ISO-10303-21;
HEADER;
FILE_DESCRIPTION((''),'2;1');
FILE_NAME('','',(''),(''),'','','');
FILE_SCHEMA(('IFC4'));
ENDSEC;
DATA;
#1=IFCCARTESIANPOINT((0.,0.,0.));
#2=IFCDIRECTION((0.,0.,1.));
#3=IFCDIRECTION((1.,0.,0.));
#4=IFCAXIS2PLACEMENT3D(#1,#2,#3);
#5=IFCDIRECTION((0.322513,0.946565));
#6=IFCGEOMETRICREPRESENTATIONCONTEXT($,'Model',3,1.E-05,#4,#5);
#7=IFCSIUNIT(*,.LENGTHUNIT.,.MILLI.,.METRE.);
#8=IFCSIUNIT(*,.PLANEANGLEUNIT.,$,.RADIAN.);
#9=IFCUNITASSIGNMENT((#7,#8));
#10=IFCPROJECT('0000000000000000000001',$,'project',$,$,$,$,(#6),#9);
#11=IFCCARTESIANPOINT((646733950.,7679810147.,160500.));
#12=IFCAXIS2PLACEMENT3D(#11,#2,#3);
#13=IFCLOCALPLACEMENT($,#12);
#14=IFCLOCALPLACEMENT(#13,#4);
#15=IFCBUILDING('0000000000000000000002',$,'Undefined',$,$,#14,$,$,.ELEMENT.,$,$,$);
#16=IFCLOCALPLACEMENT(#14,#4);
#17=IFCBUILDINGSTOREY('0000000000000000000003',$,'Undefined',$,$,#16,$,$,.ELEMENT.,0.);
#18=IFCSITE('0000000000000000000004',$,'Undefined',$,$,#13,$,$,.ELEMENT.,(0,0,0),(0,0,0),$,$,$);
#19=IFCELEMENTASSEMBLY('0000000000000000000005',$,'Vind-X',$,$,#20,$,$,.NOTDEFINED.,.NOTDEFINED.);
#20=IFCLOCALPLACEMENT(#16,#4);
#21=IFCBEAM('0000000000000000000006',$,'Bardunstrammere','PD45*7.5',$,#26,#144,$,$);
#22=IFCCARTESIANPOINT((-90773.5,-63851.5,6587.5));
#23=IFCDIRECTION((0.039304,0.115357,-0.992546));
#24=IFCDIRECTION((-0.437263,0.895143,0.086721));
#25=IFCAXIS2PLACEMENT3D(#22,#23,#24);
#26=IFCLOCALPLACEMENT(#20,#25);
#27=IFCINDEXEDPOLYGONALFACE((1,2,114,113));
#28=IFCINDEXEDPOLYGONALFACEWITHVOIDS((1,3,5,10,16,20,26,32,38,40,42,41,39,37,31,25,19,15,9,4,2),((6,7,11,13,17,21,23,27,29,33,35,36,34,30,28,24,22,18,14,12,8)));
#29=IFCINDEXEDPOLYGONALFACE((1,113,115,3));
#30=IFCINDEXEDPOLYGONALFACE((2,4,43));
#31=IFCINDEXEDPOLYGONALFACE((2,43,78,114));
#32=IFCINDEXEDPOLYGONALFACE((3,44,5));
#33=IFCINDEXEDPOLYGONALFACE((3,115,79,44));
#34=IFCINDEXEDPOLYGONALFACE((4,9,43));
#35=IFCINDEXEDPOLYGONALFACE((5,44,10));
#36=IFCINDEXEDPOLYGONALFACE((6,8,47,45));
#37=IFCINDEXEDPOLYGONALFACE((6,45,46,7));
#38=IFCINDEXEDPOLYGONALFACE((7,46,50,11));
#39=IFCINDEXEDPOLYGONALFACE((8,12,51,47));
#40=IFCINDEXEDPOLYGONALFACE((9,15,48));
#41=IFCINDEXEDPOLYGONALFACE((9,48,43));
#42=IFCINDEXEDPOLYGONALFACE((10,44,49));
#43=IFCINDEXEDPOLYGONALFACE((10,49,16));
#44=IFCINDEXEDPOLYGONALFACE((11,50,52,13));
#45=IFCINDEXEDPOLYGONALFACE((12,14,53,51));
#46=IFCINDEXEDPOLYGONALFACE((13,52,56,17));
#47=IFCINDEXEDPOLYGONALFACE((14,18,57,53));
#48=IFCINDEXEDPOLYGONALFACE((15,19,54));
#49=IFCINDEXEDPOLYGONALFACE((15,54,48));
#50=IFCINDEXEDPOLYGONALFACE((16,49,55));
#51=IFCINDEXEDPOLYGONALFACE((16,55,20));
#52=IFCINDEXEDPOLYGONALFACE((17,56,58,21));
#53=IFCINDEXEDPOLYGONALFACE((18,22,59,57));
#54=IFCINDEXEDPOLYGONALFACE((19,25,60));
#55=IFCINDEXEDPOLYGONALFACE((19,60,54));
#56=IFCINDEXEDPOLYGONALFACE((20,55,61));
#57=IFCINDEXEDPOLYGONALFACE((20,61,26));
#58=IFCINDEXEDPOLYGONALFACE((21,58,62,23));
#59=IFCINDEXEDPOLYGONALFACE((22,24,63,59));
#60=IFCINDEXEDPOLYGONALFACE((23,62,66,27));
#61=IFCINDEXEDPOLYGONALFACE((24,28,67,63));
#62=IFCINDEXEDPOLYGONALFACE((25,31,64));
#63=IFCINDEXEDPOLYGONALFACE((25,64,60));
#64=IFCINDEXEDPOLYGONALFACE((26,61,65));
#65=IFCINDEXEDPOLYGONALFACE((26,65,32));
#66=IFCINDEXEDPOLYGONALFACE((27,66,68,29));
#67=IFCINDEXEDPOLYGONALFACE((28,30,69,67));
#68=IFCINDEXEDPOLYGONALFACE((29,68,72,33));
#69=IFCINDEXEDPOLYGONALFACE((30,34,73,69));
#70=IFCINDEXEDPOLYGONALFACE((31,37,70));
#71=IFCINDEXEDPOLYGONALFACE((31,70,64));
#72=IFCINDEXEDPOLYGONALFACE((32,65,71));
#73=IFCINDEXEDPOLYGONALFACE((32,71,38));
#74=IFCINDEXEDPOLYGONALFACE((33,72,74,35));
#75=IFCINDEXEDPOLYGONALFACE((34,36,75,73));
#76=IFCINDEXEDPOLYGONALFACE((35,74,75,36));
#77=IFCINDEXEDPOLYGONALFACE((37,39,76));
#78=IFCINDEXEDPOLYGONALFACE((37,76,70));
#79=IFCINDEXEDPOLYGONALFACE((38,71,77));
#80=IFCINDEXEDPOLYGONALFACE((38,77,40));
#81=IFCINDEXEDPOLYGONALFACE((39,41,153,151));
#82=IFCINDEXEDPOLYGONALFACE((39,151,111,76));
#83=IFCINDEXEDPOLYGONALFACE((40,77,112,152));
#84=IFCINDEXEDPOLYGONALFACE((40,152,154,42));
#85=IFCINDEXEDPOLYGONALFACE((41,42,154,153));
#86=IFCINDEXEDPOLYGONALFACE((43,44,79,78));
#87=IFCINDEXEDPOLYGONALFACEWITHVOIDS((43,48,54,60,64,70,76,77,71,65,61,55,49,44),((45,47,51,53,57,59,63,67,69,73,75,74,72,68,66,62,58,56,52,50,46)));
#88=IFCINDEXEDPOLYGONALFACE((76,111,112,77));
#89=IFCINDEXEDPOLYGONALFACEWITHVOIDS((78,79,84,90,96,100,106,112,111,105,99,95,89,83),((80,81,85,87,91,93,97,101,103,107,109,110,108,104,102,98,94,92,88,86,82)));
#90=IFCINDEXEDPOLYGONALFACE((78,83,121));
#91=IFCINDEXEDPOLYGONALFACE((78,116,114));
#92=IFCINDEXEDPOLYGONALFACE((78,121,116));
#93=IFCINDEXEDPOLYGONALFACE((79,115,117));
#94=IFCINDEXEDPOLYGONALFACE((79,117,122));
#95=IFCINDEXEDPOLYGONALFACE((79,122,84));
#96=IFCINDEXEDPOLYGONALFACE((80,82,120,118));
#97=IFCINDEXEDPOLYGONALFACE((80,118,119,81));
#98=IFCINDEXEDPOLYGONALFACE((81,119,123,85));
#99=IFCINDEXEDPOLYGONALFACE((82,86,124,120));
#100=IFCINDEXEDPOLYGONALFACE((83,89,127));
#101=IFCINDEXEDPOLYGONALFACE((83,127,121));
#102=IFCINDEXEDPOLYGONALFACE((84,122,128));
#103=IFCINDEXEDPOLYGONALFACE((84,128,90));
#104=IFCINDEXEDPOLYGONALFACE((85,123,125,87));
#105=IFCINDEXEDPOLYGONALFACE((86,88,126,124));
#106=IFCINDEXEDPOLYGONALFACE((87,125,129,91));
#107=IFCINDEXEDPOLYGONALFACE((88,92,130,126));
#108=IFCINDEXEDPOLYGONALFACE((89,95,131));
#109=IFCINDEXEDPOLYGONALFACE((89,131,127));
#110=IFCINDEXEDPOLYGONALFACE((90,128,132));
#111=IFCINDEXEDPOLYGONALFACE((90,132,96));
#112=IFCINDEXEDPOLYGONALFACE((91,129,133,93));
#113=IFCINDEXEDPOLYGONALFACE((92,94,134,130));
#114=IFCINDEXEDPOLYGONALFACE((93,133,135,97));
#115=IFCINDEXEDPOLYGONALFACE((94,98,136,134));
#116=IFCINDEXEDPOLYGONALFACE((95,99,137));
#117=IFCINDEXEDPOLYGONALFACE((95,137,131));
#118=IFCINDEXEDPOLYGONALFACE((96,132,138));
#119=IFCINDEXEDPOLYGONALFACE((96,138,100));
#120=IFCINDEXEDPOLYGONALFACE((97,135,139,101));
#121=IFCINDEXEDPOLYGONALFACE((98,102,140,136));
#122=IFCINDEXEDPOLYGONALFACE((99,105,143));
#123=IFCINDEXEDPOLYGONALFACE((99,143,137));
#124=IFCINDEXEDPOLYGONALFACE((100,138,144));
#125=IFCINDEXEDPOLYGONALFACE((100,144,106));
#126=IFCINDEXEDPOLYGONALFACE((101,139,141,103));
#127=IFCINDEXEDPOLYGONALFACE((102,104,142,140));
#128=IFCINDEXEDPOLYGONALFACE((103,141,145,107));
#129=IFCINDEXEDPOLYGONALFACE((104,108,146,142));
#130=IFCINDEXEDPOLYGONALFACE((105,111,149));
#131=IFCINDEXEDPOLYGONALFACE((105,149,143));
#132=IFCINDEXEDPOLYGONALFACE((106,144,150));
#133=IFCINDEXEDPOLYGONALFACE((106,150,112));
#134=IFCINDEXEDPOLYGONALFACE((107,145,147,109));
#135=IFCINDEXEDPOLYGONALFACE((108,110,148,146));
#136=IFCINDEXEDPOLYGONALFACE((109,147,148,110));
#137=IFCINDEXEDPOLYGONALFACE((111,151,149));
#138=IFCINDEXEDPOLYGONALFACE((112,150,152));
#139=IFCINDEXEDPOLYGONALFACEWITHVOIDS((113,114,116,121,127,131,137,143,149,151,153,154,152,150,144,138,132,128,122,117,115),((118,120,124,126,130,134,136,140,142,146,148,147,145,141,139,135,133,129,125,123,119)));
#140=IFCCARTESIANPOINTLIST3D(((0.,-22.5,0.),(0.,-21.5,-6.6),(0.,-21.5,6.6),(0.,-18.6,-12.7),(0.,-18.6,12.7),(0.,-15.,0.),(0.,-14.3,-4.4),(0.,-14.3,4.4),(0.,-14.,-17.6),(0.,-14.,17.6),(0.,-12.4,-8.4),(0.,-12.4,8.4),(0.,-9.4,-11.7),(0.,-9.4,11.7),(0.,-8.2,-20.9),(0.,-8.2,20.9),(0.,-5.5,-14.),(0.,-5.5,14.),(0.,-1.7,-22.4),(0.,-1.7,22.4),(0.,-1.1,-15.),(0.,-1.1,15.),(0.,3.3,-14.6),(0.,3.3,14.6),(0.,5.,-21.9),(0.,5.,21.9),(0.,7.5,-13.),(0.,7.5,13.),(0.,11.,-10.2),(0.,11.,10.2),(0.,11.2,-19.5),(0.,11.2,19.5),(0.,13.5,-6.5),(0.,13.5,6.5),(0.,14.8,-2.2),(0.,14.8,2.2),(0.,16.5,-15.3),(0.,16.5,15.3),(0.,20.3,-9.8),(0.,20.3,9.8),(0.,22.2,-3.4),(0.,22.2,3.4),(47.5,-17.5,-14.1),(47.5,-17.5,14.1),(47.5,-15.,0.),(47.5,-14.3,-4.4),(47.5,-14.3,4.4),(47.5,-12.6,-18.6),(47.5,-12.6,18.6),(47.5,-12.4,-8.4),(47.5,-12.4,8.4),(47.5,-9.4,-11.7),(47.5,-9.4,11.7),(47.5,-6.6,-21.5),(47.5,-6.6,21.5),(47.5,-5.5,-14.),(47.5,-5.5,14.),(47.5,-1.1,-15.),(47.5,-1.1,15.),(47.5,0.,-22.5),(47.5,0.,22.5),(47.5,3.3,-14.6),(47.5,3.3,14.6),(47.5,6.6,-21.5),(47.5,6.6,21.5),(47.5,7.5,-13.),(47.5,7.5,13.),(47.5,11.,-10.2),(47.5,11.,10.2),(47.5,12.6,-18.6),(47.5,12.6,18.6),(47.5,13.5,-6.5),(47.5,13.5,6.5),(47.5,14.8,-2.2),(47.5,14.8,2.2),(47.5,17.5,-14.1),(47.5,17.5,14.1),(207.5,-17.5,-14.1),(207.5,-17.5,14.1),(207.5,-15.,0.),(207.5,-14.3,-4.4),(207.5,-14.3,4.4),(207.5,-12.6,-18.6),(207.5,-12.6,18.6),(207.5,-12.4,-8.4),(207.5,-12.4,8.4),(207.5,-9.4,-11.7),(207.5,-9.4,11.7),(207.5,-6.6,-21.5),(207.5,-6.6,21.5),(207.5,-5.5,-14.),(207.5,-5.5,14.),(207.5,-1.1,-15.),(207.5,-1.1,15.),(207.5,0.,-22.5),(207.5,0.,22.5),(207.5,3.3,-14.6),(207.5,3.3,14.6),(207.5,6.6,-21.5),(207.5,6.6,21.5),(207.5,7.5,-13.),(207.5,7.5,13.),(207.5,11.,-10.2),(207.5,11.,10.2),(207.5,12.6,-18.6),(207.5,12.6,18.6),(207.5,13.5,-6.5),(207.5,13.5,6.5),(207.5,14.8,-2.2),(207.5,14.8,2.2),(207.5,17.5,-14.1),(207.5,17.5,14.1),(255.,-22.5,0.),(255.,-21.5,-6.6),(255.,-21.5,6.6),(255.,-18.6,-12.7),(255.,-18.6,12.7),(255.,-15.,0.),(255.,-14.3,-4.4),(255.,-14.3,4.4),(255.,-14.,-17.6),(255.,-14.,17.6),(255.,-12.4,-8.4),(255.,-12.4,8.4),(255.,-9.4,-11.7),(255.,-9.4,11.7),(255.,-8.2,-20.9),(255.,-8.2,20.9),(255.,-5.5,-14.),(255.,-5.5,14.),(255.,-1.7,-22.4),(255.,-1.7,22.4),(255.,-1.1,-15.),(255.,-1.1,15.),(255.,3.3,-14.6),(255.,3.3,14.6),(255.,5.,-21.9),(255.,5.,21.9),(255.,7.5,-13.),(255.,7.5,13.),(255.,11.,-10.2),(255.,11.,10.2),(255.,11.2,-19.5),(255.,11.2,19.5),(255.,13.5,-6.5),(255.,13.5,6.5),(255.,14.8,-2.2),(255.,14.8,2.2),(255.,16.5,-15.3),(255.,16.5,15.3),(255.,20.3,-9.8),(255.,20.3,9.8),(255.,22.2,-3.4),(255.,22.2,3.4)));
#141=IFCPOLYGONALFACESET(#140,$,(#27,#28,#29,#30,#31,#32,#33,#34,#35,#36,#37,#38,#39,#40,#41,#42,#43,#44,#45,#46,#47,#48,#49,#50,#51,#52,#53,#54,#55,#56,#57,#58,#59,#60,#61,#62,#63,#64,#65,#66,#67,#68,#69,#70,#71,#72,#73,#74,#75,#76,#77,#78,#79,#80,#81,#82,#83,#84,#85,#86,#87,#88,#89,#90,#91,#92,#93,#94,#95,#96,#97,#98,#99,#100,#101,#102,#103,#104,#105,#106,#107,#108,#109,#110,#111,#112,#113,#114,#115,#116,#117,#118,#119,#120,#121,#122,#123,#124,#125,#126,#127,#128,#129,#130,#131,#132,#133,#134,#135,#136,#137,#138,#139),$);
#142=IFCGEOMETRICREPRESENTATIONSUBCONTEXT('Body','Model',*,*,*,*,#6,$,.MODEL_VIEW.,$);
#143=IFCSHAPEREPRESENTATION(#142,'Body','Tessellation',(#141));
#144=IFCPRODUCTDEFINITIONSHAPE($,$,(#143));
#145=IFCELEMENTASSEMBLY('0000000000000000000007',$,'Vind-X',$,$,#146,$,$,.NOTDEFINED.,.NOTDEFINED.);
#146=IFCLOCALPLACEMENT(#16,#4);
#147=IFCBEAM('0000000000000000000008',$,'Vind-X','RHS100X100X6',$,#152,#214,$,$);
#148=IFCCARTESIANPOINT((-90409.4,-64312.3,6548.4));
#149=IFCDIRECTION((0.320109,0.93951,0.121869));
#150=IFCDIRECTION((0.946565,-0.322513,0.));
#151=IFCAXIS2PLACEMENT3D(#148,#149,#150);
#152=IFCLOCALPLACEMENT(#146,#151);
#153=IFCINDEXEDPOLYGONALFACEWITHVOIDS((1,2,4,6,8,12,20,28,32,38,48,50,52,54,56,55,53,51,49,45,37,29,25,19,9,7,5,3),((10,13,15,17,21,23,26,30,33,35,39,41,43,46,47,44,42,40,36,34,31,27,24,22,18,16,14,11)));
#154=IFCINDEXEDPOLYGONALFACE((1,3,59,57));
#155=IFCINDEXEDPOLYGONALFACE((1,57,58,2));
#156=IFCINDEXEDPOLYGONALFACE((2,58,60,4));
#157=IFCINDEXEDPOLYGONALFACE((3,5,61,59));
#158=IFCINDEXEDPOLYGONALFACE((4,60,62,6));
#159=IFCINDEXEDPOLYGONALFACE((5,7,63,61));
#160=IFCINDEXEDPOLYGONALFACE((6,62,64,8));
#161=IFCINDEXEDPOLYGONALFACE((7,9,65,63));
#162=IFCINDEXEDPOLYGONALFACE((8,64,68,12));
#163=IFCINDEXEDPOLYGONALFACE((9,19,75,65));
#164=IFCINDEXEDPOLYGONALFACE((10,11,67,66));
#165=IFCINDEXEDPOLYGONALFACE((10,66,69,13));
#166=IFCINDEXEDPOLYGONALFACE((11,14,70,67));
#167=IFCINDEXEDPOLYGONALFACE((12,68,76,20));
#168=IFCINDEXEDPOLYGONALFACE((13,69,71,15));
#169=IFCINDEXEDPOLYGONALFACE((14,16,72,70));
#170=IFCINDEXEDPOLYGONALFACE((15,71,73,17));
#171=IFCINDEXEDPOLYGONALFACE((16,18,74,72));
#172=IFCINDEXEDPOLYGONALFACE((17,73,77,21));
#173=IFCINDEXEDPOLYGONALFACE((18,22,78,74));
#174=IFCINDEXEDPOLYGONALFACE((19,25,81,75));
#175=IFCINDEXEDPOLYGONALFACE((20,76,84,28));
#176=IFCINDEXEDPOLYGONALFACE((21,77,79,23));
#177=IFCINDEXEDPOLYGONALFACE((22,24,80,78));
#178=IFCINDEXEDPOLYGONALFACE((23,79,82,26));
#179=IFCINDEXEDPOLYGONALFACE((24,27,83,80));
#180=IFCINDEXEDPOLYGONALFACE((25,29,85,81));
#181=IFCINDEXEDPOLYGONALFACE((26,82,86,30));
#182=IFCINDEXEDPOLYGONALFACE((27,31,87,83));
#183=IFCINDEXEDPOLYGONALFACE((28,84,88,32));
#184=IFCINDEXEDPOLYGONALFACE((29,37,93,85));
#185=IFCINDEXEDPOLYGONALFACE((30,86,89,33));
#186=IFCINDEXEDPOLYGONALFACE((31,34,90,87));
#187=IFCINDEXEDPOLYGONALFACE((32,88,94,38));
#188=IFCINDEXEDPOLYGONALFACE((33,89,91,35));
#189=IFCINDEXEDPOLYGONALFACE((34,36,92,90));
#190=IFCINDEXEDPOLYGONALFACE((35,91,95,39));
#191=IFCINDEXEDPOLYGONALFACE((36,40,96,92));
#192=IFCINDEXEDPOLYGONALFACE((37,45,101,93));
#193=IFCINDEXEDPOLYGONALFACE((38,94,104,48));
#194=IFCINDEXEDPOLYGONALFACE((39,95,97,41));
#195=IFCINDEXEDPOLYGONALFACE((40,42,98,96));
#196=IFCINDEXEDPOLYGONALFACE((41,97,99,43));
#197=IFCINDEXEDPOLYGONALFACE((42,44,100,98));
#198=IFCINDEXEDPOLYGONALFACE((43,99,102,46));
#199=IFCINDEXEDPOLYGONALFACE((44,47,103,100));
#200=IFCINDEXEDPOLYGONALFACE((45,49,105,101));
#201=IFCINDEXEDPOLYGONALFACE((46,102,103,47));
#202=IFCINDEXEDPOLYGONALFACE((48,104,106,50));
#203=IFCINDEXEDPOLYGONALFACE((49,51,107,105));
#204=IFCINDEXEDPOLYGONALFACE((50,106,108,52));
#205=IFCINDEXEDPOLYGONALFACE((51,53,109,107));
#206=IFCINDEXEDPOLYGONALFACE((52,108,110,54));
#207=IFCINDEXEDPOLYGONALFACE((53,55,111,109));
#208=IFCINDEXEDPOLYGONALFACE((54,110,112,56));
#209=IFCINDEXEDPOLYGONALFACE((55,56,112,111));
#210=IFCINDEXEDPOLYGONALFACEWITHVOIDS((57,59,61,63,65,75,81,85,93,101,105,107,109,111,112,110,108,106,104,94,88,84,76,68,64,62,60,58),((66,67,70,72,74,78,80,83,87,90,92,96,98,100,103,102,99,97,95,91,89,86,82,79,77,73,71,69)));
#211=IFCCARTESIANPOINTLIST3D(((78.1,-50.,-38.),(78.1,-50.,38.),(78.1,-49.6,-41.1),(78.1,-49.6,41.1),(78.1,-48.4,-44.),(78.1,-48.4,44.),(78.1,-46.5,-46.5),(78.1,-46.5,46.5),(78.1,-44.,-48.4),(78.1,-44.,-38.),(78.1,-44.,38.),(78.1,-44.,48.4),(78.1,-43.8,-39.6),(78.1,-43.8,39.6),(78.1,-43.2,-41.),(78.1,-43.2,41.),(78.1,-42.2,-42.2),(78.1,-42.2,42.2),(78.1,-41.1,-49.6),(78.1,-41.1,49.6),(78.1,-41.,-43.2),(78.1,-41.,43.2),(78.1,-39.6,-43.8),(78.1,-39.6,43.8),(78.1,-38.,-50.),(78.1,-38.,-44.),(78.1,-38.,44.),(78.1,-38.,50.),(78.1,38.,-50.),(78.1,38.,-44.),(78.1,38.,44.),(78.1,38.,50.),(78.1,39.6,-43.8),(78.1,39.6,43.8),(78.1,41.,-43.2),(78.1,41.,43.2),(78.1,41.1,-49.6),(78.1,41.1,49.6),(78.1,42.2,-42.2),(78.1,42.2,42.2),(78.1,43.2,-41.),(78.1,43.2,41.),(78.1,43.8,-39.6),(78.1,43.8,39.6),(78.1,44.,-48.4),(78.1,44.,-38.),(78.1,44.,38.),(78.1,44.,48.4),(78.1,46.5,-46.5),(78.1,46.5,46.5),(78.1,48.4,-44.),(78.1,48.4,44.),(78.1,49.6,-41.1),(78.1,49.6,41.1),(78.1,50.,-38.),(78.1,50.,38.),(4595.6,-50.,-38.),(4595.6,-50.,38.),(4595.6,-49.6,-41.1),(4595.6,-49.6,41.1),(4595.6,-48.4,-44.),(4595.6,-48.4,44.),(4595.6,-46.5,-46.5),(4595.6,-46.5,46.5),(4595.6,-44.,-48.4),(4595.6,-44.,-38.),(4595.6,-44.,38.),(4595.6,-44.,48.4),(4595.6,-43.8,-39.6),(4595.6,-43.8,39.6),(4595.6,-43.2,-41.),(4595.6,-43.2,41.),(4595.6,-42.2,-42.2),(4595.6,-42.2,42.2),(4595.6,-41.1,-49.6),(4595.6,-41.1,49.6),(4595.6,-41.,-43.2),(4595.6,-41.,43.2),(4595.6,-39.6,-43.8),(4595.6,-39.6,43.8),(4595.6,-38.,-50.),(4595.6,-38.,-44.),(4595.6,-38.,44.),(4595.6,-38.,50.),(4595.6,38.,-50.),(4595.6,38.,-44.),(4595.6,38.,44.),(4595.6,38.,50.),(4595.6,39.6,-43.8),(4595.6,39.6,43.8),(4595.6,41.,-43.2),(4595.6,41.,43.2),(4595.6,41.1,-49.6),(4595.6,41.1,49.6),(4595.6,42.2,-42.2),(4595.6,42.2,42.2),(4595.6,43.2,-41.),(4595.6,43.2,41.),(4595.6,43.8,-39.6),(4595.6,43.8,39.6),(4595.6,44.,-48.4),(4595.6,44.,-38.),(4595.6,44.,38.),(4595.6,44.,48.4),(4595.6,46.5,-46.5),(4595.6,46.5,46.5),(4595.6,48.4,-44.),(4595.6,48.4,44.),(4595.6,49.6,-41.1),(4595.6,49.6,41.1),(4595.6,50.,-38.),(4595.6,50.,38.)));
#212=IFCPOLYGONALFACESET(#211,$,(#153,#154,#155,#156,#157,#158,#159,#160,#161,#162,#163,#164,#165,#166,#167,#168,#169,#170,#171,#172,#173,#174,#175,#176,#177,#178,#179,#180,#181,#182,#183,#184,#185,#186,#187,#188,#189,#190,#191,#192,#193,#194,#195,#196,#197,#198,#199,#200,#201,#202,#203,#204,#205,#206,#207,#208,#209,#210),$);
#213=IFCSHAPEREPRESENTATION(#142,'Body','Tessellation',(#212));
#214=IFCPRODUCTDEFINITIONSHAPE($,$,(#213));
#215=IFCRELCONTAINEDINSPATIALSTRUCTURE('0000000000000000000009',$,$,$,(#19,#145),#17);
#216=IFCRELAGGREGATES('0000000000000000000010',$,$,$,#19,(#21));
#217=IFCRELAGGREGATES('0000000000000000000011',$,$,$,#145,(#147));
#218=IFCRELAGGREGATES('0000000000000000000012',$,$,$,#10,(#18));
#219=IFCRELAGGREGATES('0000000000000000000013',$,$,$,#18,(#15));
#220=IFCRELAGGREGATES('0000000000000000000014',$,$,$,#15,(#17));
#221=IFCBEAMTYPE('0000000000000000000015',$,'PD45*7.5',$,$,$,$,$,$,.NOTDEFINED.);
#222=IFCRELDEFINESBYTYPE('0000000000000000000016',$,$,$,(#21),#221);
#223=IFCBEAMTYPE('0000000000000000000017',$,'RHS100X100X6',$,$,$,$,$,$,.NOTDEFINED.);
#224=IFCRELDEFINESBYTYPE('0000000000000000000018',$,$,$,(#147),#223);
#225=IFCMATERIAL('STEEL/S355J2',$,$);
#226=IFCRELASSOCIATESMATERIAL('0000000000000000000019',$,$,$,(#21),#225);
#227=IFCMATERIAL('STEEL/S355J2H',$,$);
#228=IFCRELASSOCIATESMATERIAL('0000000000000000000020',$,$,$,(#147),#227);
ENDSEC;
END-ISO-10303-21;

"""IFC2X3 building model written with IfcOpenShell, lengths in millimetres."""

from ifc_helpers import new_model, si_unit, direction, frame, origin_with_axes, origin_2d_with_axis, place, context, subcontext, project, spatial, rectangle, hollow_rectangle, hollow_circle, extrude, boolean, clip, halfspace, material, type_object, element, aggregate, save


model = new_model("IFC2X3")

# Units and contexts
model_context = context("Model", 3, precision=1e-05, world=origin_with_axes(), true_north=direction((0.322513, 0.946565)))
body_context = subcontext(model_context, "Body", "Model", "MODEL_VIEW")
ifc_project = project(units=[si_unit("LENGTHUNIT", "METRE", prefix="MILLI"), si_unit("PLANEANGLEUNIT", "RADIAN")], contexts=[model_context])

# Site, building, storey
site_placement = place(None, frame((646733950.0, 7679810147.0, 160500.0), z_axis=(0.0, 0.0, 1.0), x_axis=(1.0, 0.0, 0.0)))
site = spatial("IfcSite", under=ifc_project, at=site_placement, Name="Undefined", CompositionType="ELEMENT", RefLatitude=(0, 0, 0), RefLongitude=(0, 0, 0))
building_placement = place(site_placement, origin_with_axes())
building = spatial("IfcBuilding", under=site, at=building_placement, Name="Undefined", CompositionType="ELEMENT")
storey_placement = place(building_placement, origin_with_axes())
storey = spatial("IfcBuildingStorey", under=building, at=storey_placement, Name="Undefined", CompositionType="ELEMENT", Elevation=0.0)

# Shared definitions
ifc_material_1 = material(Name="STEEL/S355J2H")

# Element assembly, beam
assembly_1_placement = place(storey_placement, origin_with_axes())
assembly_1 = element("IfcElementAssembly", 1, at=assembly_1_placement, inside=storey, Name="Vind-X", AssemblyPlace="NOTDEFINED", PredefinedType="NOTDEFINED")
ifc_material_2 = material(Name="STEEL/S355J2")
beam_type_1 = type_object("IfcBeamType", Name="PD45*7.5", PredefinedType="NOTDEFINED")
beam_1_placement = place(assembly_1_placement, frame((-90773.5, -63851.5, 6587.5), z_axis=(0.039304, 0.115357, -0.992546), x_axis=(-0.437263, 0.895143, 0.086721)))
beam_1 = element("IfcBeam", 2, at=beam_1_placement, type_object=beam_type_1, material=ifc_material_2, Name="Bardunstrammere", Description="PD45*7.5", context=body_context, shape_type="CSG", body=[
    boolean("DIFFERENCE", extrude(hollow_circle(Radius=22.5, WallThickness=7.5, at=origin_2d_with_axis()), frame((255.0, 0.0, 0.0), z_axis=(-1.0, 0.0, 0.0), x_axis=(0.0, -1.0, 0.0)), (0.0, 0.0, 1.0), 255.0), extrude(rectangle(XDim=35.0, YDim=90.0, at=origin_2d_with_axis()), frame((207.5, 0.0, 0.0), z_axis=(-1.0, 0.0, 0.0), x_axis=(0.0, -1.0, 0.0)), (0.0, 0.0, 1.0), 160.0)),
])

# Element assembly, beam
beam_type_2 = type_object("IfcBeamType", Name="RHS100X100X6", PredefinedType="NOTDEFINED")
assembly_2_placement = place(storey_placement, origin_with_axes())
assembly_2 = element("IfcElementAssembly", 3, at=assembly_2_placement, inside=storey, Name="Vind-X", AssemblyPlace="NOTDEFINED", PredefinedType="NOTDEFINED")
beam_2_placement = place(assembly_2_placement, frame((-90409.4, -64312.3, 6548.4), z_axis=(0.320109, 0.93951, 0.121869), x_axis=(0.946565, -0.322513, 0.0)))
beam_2 = element("IfcBeam", 4, at=beam_2_placement, type_object=beam_type_2, material=ifc_material_1, Name="Vind-X", Description="RHS100X100X6", context=body_context, shape_type="Clipping", body=[
    clip(clip(extrude(hollow_rectangle(XDim=100.0, YDim=100.0, WallThickness=6.0, InnerFilletRadius=6.0, OuterFilletRadius=12.0, at=origin_2d_with_axis()), frame((4674.6, 0.0, 0.0), z_axis=(-1.0, 0.0, 0.0), x_axis=(0.0, -1.0, 0.0)), (0.0, 0.0, 1.0), 4674.6), halfspace(frame((4595.6, 22.5, 0.0), z_axis=(-1.0, 0.0, 0.0), x_axis=(0.0, 0.0, 1.0)), True)), halfspace(frame((78.1, 22.5, 0.0), z_axis=(1.0, 0.0, 0.0), x_axis=(0.0, 0.0, -1.0)), True)),
])

aggregate(assembly_1, [beam_1])

aggregate(assembly_2, [beam_2])

save(model, "model.ifc")
